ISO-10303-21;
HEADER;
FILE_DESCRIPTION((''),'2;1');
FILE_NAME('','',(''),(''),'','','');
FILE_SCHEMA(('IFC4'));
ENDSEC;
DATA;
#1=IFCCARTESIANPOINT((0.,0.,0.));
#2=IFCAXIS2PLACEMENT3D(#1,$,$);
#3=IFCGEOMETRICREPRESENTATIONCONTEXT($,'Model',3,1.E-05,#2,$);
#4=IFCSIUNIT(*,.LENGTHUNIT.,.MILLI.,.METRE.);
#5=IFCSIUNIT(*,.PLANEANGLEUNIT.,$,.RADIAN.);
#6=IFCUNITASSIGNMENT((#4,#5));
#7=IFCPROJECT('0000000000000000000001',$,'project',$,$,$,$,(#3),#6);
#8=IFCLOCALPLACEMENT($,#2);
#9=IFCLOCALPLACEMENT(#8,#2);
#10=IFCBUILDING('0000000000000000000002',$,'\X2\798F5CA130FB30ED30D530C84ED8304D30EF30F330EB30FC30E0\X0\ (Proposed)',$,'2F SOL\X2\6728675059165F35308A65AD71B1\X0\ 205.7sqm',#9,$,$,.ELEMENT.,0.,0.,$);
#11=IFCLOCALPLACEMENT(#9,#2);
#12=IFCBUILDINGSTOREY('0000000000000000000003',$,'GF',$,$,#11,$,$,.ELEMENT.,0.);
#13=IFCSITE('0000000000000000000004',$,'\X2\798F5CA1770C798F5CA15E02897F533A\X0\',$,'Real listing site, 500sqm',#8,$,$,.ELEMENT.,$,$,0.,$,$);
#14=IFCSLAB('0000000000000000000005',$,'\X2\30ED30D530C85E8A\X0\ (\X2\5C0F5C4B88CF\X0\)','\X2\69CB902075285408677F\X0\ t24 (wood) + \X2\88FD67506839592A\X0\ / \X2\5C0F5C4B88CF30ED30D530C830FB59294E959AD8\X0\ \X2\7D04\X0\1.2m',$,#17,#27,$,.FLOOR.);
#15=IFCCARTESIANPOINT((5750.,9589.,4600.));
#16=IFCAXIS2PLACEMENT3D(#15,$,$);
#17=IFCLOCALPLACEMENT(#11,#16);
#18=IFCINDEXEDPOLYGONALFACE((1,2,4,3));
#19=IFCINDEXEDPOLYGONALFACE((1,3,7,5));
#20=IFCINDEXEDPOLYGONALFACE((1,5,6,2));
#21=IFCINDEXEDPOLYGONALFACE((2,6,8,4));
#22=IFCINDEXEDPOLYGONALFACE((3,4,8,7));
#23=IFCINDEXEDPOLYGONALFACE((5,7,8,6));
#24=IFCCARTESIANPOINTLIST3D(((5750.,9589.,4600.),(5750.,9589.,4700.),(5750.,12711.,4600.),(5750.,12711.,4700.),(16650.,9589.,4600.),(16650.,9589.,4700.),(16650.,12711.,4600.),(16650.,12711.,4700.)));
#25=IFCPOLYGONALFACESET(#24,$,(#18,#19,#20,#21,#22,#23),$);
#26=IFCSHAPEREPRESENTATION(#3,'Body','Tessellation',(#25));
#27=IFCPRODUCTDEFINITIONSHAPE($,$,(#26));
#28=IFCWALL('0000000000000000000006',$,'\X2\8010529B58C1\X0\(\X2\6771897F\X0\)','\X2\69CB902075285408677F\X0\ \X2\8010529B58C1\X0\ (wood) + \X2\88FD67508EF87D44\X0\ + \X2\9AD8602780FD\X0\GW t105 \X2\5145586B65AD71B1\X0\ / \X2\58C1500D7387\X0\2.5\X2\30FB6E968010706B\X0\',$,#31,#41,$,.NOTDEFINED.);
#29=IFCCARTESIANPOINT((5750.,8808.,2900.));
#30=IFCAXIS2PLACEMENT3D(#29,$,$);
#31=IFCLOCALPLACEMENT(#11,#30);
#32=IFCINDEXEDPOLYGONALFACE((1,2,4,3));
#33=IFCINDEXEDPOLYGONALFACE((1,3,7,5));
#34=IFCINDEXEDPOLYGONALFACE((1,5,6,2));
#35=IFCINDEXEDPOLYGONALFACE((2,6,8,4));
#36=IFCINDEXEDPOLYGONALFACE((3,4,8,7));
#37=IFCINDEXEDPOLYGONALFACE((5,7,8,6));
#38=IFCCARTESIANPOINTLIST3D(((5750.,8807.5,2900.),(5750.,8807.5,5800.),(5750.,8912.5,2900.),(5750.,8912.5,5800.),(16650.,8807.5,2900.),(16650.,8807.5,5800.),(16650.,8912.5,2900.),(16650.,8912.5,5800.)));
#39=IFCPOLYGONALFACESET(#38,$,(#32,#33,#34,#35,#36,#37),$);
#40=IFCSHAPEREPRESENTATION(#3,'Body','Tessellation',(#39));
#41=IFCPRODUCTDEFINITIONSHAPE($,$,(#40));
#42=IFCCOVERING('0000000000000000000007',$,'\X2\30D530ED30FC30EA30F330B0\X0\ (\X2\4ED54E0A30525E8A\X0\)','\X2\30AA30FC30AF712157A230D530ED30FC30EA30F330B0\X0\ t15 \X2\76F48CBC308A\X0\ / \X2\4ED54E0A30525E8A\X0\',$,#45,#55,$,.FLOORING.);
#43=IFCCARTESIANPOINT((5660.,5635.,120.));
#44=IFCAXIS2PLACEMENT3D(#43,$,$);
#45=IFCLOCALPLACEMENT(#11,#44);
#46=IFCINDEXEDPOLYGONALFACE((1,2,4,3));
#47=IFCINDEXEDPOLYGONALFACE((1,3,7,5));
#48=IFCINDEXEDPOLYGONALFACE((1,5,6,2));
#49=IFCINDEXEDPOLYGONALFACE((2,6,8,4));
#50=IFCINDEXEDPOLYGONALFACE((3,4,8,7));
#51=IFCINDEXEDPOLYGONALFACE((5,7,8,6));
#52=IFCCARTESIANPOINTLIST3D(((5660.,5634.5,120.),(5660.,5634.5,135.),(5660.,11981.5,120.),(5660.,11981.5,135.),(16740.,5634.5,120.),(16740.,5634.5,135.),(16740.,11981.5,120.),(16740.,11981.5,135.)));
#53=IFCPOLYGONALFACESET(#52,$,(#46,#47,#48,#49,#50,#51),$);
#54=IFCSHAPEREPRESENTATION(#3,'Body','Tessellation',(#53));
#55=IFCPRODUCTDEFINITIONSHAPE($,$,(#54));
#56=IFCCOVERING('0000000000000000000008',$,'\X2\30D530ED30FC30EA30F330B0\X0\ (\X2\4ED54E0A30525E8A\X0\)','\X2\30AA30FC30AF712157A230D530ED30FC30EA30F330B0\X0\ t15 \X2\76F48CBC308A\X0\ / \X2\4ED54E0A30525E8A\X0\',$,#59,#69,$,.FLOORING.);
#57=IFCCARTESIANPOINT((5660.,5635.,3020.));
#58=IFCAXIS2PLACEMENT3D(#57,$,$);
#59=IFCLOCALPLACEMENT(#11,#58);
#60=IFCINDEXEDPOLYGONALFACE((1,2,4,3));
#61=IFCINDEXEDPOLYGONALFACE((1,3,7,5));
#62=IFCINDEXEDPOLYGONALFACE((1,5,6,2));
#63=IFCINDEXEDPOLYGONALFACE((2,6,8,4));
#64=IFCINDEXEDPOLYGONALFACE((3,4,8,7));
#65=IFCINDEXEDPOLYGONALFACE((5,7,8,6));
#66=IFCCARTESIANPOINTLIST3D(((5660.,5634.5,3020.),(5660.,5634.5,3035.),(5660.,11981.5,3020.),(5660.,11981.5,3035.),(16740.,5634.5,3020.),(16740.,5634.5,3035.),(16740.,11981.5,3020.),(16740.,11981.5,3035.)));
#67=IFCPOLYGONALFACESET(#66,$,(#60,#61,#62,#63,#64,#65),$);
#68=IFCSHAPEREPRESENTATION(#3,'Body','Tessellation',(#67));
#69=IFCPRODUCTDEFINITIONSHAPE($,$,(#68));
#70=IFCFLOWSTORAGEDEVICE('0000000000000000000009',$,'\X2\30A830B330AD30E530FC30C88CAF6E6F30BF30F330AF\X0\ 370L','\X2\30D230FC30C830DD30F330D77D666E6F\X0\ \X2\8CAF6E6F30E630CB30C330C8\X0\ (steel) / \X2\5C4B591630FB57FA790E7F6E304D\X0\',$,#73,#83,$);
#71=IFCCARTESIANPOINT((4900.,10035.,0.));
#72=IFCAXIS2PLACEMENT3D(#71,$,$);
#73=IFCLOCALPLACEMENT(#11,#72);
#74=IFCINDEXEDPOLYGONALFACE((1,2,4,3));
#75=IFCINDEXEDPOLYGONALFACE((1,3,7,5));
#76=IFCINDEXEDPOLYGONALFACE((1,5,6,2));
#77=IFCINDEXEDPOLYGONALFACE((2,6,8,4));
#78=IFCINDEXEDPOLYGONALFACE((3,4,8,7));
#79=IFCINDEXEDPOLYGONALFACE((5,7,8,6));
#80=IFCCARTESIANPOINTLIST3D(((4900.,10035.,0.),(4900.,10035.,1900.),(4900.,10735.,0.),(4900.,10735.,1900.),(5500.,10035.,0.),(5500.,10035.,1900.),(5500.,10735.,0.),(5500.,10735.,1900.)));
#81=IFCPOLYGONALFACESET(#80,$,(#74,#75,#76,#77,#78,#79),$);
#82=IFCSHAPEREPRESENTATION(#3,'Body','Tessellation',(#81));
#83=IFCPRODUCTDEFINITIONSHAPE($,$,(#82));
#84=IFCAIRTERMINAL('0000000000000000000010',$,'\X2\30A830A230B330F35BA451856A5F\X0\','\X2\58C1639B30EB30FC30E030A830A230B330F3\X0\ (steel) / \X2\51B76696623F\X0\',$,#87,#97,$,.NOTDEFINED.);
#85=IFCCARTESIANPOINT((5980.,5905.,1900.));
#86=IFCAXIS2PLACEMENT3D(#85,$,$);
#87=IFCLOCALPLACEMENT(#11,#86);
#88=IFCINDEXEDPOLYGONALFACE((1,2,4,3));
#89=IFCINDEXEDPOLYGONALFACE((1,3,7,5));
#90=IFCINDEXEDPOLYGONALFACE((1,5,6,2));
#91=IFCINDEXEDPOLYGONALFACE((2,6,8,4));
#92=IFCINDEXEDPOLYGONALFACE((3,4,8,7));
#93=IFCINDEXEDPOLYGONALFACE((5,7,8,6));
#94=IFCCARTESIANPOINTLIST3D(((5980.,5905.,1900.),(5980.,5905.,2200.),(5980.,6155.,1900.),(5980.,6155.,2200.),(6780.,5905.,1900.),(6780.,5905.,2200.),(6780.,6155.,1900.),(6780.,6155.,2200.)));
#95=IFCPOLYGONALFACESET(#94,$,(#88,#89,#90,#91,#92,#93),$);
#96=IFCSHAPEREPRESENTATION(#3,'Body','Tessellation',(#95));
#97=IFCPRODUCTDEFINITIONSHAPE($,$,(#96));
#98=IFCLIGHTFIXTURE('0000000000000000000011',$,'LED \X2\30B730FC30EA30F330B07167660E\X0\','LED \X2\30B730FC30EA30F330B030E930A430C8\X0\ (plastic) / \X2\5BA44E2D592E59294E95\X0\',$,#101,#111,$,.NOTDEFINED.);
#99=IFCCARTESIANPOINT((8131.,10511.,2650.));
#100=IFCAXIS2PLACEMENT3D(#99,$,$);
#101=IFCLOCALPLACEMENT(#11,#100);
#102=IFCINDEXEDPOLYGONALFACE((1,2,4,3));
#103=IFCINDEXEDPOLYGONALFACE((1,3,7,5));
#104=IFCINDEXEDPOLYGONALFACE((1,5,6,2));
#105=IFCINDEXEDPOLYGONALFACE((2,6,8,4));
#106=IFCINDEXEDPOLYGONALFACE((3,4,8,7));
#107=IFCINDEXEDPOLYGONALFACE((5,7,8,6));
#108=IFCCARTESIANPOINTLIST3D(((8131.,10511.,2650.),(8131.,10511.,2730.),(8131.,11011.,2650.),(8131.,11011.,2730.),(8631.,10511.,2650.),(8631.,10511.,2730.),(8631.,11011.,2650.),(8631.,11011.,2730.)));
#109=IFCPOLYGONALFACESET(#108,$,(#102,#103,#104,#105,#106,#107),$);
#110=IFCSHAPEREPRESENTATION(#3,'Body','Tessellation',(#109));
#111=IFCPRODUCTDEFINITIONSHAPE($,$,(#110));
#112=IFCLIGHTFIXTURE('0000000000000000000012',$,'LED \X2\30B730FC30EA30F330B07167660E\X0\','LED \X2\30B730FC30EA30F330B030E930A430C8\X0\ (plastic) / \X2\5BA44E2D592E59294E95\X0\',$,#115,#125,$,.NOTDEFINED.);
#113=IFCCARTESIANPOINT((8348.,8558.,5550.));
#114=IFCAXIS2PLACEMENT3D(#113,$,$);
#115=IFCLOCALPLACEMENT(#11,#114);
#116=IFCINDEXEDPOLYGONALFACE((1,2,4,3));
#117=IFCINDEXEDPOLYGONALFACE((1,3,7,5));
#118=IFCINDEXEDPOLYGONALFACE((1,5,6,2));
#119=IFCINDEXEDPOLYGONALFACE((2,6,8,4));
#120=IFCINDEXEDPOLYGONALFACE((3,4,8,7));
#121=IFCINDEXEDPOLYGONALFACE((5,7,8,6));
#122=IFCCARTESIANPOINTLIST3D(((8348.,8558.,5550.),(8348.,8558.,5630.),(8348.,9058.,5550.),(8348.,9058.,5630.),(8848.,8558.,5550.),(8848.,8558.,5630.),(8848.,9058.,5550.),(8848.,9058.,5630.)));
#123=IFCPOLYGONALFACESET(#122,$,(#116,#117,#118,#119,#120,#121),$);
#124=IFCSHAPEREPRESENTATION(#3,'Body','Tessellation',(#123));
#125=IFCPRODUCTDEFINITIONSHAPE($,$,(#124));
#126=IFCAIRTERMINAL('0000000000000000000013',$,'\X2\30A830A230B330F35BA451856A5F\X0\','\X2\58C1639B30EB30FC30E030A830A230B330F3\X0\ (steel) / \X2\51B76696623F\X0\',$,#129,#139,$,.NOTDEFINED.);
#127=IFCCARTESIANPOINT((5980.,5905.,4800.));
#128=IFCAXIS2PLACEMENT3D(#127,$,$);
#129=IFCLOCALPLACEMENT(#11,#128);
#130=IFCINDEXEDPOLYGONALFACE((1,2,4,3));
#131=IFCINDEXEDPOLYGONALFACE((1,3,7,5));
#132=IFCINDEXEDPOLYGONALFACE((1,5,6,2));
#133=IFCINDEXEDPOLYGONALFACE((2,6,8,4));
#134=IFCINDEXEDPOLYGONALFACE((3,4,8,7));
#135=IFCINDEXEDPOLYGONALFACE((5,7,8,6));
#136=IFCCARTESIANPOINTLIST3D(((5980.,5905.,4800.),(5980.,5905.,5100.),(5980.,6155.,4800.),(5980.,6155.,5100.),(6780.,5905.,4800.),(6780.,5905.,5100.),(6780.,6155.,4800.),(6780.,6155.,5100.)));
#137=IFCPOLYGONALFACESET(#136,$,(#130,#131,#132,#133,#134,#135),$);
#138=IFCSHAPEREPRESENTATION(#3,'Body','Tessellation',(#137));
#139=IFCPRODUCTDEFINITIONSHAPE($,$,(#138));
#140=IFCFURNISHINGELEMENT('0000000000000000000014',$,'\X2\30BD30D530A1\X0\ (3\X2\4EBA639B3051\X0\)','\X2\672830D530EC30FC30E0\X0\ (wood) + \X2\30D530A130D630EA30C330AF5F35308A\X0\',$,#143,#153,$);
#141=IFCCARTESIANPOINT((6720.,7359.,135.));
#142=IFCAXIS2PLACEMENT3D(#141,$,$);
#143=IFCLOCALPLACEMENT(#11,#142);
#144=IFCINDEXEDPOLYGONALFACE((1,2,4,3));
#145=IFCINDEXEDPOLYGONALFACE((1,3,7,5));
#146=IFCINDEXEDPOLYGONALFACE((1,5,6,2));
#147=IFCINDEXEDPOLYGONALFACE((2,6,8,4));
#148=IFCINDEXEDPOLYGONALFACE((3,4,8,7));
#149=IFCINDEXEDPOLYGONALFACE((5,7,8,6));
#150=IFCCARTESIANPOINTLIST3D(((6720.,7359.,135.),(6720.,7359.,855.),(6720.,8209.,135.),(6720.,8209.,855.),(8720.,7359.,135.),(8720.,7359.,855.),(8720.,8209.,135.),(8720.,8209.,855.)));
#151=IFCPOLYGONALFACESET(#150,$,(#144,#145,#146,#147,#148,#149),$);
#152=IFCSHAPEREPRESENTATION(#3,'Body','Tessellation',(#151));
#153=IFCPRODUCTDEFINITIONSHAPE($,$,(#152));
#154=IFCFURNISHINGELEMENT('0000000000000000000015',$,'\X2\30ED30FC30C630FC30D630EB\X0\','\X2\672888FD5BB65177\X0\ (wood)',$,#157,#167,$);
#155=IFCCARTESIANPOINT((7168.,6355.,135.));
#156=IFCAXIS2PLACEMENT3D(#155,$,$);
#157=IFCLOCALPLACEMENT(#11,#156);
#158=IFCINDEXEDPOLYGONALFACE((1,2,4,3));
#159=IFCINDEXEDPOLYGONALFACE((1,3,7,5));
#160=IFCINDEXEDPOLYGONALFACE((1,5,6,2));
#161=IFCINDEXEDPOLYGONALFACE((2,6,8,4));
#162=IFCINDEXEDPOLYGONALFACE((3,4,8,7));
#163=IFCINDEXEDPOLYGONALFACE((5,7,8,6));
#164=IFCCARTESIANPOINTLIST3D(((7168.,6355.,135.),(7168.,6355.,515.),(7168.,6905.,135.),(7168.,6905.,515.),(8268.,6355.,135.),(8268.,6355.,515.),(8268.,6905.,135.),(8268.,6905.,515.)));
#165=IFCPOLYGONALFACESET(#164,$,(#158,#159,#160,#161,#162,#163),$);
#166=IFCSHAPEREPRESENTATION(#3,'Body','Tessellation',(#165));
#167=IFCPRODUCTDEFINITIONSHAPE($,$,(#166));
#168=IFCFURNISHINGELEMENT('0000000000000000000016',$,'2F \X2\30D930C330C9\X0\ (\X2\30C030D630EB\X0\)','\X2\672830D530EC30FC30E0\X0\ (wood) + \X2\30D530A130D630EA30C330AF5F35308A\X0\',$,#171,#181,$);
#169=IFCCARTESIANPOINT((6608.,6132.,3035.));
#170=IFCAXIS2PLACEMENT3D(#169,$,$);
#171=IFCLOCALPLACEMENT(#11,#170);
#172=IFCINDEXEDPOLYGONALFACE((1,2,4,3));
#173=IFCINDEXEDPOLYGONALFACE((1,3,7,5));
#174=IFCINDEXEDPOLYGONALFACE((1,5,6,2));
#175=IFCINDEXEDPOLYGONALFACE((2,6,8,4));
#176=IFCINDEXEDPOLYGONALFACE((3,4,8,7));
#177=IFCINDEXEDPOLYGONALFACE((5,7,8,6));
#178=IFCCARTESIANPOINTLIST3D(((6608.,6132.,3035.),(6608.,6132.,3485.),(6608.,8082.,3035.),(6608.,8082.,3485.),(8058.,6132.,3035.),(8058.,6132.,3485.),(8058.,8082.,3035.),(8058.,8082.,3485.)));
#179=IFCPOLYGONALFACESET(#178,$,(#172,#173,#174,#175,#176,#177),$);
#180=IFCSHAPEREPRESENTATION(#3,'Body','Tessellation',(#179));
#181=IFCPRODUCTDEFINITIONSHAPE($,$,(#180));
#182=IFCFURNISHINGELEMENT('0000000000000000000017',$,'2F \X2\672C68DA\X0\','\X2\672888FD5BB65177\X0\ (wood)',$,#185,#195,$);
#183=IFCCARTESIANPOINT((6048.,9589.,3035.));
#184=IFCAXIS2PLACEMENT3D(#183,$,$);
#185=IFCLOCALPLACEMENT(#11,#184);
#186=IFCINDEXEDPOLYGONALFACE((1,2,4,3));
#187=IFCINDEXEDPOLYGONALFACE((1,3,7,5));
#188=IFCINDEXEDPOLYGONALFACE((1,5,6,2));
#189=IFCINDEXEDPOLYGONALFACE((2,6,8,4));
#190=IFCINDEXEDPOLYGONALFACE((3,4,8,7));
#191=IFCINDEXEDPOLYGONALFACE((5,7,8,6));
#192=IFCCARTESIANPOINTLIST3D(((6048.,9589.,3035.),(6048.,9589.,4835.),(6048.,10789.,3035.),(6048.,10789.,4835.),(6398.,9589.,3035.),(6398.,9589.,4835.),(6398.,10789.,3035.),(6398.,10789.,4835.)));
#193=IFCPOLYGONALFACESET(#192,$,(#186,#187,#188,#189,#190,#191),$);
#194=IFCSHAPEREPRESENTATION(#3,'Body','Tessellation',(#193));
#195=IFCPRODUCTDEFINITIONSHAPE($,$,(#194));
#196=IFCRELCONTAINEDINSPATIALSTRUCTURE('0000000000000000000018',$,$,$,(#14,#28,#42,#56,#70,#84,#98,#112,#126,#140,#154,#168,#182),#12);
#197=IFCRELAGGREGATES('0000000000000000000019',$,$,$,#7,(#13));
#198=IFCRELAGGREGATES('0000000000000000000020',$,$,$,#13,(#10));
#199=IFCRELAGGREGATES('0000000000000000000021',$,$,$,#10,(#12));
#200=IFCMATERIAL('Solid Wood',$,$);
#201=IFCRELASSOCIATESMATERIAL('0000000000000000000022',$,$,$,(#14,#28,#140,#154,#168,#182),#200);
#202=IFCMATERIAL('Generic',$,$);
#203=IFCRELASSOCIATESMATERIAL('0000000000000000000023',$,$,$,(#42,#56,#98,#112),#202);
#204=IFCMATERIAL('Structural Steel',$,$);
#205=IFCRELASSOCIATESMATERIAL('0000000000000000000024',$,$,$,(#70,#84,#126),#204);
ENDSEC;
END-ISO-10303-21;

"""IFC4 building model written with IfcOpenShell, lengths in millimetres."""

from ifc_helpers import new_model, si_unit, frame, frame_2d, origin, place, context, project, spatial, rectangle, extrude, material, element, save


model = new_model("IFC4")

# Units and contexts
model_context = context("Model", 3, precision=1e-05, world=origin())
ifc_project = project(units=[si_unit("LENGTHUNIT", "METRE", prefix="MILLI"), si_unit("PLANEANGLEUNIT", "RADIAN")], contexts=[model_context])

# Site, building, storey
site_placement = place(None, origin())
site = spatial("IfcSite", under=ifc_project, at=site_placement, Name="福岡県福岡市西区", ObjectType="Real listing site, 500sqm", CompositionType="ELEMENT", RefElevation=0.0)
building_placement = place(site_placement, origin())
building = spatial("IfcBuilding", under=site, at=building_placement, Name="福岡・ロフト付きワンルーム (Proposed)", ObjectType="2F SOL木材外張り断熱 205.7sqm", CompositionType="ELEMENT", ElevationOfRefHeight=0.0, ElevationOfTerrain=0.0)
storey_placement = place(building_placement, origin())
storey = spatial("IfcBuildingStorey", under=building, at=storey_placement, Name="GF", CompositionType="ELEMENT", Elevation=0.0)

# Shared definitions
ifc_material_1 = material(Name="Solid Wood")

# Slab
slab_placement = place(storey_placement, frame((5750.0, 9589.0, 4600.0)))
element("IfcSlab", 1, at=slab_placement, inside=storey, material=ifc_material_1, Name="ロフト床 (小屋裏)", Description="構造用合板 t24 (wood) + 製材根太 / 小屋裏ロフト・天井高 約1.2m", PredefinedType="FLOOR", context=model_context, shape_type="SweptSolid", body=[
    extrude(rectangle(XDim=10900.0, YDim=3122.0, at=frame_2d((5450.0, 1561.0))), frame((5750.0, 9589.0, 4600.0)), (0.0, 0.0, 1.0), 100.0),
])

# Wall
wall_1_placement = place(storey_placement, frame((5750.0, 8808.0, 2900.0)))
element("IfcWall", 2, at=wall_1_placement, inside=storey, material=ifc_material_1, Name="耐力壁(東西)", Description="構造用合板 耐力壁 (wood) + 製材軸組 + 高性能GW t105 充填断熱 / 壁倍率2.5・準耐火", PredefinedType="NOTDEFINED", context=model_context, shape_type="SweptSolid", body=[
    extrude(rectangle(XDim=10900.0, YDim=105.0, at=frame_2d((5450.0, 52.0))), frame((5750.0, 8808.0, 2900.0)), (0.0, 0.0, 1.0), 2900.0),
])

# Coverings
ifc_material_2 = material(Name="Generic")
covering_1_placement = place(storey_placement, frame((5660.0, 5635.0, 120.0)))
element("IfcCovering", 3, at=covering_1_placement, inside=storey, material=ifc_material_2, Name="フローリング (仕上げ床)", Description="オーク無垢フローリング t15 直貼り / 仕上げ床", PredefinedType="FLOORING", context=model_context, shape_type="SweptSolid", body=[
    extrude(rectangle(XDim=11080.0, YDim=6347.0, at=frame_2d((5540.0, 3173.0))), frame((5660.0, 5635.0, 120.0)), (0.0, 0.0, 1.0), 15.0),
])
covering_2_placement = place(storey_placement, frame((5660.0, 5635.0, 3020.0)))
element("IfcCovering", 4, at=covering_2_placement, inside=storey, material=ifc_material_2, Name="フローリング (仕上げ床)", Description="オーク無垢フローリング t15 直貼り / 仕上げ床", PredefinedType="FLOORING", context=model_context, shape_type="SweptSolid", body=[
    extrude(rectangle(XDim=11080.0, YDim=6347.0, at=frame_2d((5540.0, 3173.0))), frame((5660.0, 5635.0, 3020.0)), (0.0, 0.0, 1.0), 15.0),
])

# Flow storage device
ifc_material_3 = material(Name="Structural Steel")
flow_storage_device_placement = place(storey_placement, frame((4900.0, 10035.0, 0.0)))
element("IfcFlowStorageDevice", 5, at=flow_storage_device_placement, inside=storey, material=ifc_material_3, Name="エコキュート貯湯タンク 370L", Description="ヒートポンプ給湯 貯湯ユニット (steel) / 屋外・基礎置き", context=model_context, shape_type="SweptSolid", body=[
    extrude(rectangle(XDim=600.0, YDim=700.0, at=frame_2d((300.0, 350.0))), frame((4900.0, 10035.0, 0.0)), (0.0, 0.0, 1.0), 1900.0),
])

# Air terminal
air_terminal_1_placement = place(storey_placement, frame((5980.0, 5905.0, 1900.0)))
element("IfcAirTerminal", 6, at=air_terminal_1_placement, inside=storey, material=ifc_material_3, Name="エアコン室内機", Description="壁掛ルームエアコン (steel) / 冷暖房", PredefinedType="NOTDEFINED", context=model_context, shape_type="SweptSolid", body=[
    extrude(rectangle(XDim=800.0, YDim=250.0, at=frame_2d((400.0, 125.0))), frame((5980.0, 5905.0, 1900.0)), (0.0, 0.0, 1.0), 300.0),
])

# Light fixtures
light_fixture_1_placement = place(storey_placement, frame((8131.0, 10511.0, 2650.0)))
element("IfcLightFixture", 7, at=light_fixture_1_placement, inside=storey, material=ifc_material_2, Name="LED シーリング照明", Description="LED シーリングライト (plastic) / 室中央天井", PredefinedType="NOTDEFINED", context=model_context, shape_type="SweptSolid", body=[
    extrude(rectangle(XDim=500.0, YDim=500.0, at=frame_2d((250.0, 250.0))), frame((8131.0, 10511.0, 2650.0)), (0.0, 0.0, 1.0), 80.0),
])
light_fixture_2_placement = place(storey_placement, frame((8348.0, 8558.0, 5550.0)))
element("IfcLightFixture", 8, at=light_fixture_2_placement, inside=storey, material=ifc_material_2, Name="LED シーリング照明", Description="LED シーリングライト (plastic) / 室中央天井", PredefinedType="NOTDEFINED", context=model_context, shape_type="SweptSolid", body=[
    extrude(rectangle(XDim=500.0, YDim=500.0, at=frame_2d((250.0, 250.0))), frame((8348.0, 8558.0, 5550.0)), (0.0, 0.0, 1.0), 80.0),
])

# Air terminal
air_terminal_2_placement = place(storey_placement, frame((5980.0, 5905.0, 4800.0)))
element("IfcAirTerminal", 9, at=air_terminal_2_placement, inside=storey, material=ifc_material_3, Name="エアコン室内機", Description="壁掛ルームエアコン (steel) / 冷暖房", PredefinedType="NOTDEFINED", context=model_context, shape_type="SweptSolid", body=[
    extrude(rectangle(XDim=800.0, YDim=250.0, at=frame_2d((400.0, 125.0))), frame((5980.0, 5905.0, 4800.0)), (0.0, 0.0, 1.0), 300.0),
])

# Furnishing elements
furnishing_1_placement = place(storey_placement, frame((6720.0, 7359.0, 135.0)))
element("IfcFurnishingElement", 10, at=furnishing_1_placement, inside=storey, material=ifc_material_1, Name="ソファ (3人掛け)", Description="木フレーム (wood) + ファブリック張り", context=model_context, shape_type="SweptSolid", body=[
    extrude(rectangle(XDim=2000.0, YDim=850.0, at=frame_2d((1000.0, 425.0))), frame((6720.0, 7359.0, 135.0)), (0.0, 0.0, 1.0), 720.0),
])
furnishing_2_placement = place(storey_placement, frame((7168.0, 6355.0, 135.0)))
element("IfcFurnishingElement", 11, at=furnishing_2_placement, inside=storey, material=ifc_material_1, Name="ローテーブル", Description="木製家具 (wood)", context=model_context, shape_type="SweptSolid", body=[
    extrude(rectangle(XDim=1100.0, YDim=550.0, at=frame_2d((550.0, 275.0))), frame((7168.0, 6355.0, 135.0)), (0.0, 0.0, 1.0), 380.0),
])
furnishing_3_placement = place(storey_placement, frame((6608.0, 6132.0, 3035.0)))
element("IfcFurnishingElement", 12, at=furnishing_3_placement, inside=storey, material=ifc_material_1, Name="2F ベッド (ダブル)", Description="木フレーム (wood) + ファブリック張り", context=model_context, shape_type="SweptSolid", body=[
    extrude(rectangle(XDim=1450.0, YDim=1950.0, at=frame_2d((725.0, 975.0))), frame((6608.0, 6132.0, 3035.0)), (0.0, 0.0, 1.0), 450.0),
])
furnishing_4_placement = place(storey_placement, frame((6048.0, 9589.0, 3035.0)))
element("IfcFurnishingElement", 13, at=furnishing_4_placement, inside=storey, material=ifc_material_1, Name="2F 本棚", Description="木製家具 (wood)", context=model_context, shape_type="SweptSolid", body=[
    extrude(rectangle(XDim=350.0, YDim=1200.0, at=frame_2d((175.0, 600.0))), frame((6048.0, 9589.0, 3035.0)), (0.0, 0.0, 1.0), 1800.0),
])

save(model, "model.ifc")
